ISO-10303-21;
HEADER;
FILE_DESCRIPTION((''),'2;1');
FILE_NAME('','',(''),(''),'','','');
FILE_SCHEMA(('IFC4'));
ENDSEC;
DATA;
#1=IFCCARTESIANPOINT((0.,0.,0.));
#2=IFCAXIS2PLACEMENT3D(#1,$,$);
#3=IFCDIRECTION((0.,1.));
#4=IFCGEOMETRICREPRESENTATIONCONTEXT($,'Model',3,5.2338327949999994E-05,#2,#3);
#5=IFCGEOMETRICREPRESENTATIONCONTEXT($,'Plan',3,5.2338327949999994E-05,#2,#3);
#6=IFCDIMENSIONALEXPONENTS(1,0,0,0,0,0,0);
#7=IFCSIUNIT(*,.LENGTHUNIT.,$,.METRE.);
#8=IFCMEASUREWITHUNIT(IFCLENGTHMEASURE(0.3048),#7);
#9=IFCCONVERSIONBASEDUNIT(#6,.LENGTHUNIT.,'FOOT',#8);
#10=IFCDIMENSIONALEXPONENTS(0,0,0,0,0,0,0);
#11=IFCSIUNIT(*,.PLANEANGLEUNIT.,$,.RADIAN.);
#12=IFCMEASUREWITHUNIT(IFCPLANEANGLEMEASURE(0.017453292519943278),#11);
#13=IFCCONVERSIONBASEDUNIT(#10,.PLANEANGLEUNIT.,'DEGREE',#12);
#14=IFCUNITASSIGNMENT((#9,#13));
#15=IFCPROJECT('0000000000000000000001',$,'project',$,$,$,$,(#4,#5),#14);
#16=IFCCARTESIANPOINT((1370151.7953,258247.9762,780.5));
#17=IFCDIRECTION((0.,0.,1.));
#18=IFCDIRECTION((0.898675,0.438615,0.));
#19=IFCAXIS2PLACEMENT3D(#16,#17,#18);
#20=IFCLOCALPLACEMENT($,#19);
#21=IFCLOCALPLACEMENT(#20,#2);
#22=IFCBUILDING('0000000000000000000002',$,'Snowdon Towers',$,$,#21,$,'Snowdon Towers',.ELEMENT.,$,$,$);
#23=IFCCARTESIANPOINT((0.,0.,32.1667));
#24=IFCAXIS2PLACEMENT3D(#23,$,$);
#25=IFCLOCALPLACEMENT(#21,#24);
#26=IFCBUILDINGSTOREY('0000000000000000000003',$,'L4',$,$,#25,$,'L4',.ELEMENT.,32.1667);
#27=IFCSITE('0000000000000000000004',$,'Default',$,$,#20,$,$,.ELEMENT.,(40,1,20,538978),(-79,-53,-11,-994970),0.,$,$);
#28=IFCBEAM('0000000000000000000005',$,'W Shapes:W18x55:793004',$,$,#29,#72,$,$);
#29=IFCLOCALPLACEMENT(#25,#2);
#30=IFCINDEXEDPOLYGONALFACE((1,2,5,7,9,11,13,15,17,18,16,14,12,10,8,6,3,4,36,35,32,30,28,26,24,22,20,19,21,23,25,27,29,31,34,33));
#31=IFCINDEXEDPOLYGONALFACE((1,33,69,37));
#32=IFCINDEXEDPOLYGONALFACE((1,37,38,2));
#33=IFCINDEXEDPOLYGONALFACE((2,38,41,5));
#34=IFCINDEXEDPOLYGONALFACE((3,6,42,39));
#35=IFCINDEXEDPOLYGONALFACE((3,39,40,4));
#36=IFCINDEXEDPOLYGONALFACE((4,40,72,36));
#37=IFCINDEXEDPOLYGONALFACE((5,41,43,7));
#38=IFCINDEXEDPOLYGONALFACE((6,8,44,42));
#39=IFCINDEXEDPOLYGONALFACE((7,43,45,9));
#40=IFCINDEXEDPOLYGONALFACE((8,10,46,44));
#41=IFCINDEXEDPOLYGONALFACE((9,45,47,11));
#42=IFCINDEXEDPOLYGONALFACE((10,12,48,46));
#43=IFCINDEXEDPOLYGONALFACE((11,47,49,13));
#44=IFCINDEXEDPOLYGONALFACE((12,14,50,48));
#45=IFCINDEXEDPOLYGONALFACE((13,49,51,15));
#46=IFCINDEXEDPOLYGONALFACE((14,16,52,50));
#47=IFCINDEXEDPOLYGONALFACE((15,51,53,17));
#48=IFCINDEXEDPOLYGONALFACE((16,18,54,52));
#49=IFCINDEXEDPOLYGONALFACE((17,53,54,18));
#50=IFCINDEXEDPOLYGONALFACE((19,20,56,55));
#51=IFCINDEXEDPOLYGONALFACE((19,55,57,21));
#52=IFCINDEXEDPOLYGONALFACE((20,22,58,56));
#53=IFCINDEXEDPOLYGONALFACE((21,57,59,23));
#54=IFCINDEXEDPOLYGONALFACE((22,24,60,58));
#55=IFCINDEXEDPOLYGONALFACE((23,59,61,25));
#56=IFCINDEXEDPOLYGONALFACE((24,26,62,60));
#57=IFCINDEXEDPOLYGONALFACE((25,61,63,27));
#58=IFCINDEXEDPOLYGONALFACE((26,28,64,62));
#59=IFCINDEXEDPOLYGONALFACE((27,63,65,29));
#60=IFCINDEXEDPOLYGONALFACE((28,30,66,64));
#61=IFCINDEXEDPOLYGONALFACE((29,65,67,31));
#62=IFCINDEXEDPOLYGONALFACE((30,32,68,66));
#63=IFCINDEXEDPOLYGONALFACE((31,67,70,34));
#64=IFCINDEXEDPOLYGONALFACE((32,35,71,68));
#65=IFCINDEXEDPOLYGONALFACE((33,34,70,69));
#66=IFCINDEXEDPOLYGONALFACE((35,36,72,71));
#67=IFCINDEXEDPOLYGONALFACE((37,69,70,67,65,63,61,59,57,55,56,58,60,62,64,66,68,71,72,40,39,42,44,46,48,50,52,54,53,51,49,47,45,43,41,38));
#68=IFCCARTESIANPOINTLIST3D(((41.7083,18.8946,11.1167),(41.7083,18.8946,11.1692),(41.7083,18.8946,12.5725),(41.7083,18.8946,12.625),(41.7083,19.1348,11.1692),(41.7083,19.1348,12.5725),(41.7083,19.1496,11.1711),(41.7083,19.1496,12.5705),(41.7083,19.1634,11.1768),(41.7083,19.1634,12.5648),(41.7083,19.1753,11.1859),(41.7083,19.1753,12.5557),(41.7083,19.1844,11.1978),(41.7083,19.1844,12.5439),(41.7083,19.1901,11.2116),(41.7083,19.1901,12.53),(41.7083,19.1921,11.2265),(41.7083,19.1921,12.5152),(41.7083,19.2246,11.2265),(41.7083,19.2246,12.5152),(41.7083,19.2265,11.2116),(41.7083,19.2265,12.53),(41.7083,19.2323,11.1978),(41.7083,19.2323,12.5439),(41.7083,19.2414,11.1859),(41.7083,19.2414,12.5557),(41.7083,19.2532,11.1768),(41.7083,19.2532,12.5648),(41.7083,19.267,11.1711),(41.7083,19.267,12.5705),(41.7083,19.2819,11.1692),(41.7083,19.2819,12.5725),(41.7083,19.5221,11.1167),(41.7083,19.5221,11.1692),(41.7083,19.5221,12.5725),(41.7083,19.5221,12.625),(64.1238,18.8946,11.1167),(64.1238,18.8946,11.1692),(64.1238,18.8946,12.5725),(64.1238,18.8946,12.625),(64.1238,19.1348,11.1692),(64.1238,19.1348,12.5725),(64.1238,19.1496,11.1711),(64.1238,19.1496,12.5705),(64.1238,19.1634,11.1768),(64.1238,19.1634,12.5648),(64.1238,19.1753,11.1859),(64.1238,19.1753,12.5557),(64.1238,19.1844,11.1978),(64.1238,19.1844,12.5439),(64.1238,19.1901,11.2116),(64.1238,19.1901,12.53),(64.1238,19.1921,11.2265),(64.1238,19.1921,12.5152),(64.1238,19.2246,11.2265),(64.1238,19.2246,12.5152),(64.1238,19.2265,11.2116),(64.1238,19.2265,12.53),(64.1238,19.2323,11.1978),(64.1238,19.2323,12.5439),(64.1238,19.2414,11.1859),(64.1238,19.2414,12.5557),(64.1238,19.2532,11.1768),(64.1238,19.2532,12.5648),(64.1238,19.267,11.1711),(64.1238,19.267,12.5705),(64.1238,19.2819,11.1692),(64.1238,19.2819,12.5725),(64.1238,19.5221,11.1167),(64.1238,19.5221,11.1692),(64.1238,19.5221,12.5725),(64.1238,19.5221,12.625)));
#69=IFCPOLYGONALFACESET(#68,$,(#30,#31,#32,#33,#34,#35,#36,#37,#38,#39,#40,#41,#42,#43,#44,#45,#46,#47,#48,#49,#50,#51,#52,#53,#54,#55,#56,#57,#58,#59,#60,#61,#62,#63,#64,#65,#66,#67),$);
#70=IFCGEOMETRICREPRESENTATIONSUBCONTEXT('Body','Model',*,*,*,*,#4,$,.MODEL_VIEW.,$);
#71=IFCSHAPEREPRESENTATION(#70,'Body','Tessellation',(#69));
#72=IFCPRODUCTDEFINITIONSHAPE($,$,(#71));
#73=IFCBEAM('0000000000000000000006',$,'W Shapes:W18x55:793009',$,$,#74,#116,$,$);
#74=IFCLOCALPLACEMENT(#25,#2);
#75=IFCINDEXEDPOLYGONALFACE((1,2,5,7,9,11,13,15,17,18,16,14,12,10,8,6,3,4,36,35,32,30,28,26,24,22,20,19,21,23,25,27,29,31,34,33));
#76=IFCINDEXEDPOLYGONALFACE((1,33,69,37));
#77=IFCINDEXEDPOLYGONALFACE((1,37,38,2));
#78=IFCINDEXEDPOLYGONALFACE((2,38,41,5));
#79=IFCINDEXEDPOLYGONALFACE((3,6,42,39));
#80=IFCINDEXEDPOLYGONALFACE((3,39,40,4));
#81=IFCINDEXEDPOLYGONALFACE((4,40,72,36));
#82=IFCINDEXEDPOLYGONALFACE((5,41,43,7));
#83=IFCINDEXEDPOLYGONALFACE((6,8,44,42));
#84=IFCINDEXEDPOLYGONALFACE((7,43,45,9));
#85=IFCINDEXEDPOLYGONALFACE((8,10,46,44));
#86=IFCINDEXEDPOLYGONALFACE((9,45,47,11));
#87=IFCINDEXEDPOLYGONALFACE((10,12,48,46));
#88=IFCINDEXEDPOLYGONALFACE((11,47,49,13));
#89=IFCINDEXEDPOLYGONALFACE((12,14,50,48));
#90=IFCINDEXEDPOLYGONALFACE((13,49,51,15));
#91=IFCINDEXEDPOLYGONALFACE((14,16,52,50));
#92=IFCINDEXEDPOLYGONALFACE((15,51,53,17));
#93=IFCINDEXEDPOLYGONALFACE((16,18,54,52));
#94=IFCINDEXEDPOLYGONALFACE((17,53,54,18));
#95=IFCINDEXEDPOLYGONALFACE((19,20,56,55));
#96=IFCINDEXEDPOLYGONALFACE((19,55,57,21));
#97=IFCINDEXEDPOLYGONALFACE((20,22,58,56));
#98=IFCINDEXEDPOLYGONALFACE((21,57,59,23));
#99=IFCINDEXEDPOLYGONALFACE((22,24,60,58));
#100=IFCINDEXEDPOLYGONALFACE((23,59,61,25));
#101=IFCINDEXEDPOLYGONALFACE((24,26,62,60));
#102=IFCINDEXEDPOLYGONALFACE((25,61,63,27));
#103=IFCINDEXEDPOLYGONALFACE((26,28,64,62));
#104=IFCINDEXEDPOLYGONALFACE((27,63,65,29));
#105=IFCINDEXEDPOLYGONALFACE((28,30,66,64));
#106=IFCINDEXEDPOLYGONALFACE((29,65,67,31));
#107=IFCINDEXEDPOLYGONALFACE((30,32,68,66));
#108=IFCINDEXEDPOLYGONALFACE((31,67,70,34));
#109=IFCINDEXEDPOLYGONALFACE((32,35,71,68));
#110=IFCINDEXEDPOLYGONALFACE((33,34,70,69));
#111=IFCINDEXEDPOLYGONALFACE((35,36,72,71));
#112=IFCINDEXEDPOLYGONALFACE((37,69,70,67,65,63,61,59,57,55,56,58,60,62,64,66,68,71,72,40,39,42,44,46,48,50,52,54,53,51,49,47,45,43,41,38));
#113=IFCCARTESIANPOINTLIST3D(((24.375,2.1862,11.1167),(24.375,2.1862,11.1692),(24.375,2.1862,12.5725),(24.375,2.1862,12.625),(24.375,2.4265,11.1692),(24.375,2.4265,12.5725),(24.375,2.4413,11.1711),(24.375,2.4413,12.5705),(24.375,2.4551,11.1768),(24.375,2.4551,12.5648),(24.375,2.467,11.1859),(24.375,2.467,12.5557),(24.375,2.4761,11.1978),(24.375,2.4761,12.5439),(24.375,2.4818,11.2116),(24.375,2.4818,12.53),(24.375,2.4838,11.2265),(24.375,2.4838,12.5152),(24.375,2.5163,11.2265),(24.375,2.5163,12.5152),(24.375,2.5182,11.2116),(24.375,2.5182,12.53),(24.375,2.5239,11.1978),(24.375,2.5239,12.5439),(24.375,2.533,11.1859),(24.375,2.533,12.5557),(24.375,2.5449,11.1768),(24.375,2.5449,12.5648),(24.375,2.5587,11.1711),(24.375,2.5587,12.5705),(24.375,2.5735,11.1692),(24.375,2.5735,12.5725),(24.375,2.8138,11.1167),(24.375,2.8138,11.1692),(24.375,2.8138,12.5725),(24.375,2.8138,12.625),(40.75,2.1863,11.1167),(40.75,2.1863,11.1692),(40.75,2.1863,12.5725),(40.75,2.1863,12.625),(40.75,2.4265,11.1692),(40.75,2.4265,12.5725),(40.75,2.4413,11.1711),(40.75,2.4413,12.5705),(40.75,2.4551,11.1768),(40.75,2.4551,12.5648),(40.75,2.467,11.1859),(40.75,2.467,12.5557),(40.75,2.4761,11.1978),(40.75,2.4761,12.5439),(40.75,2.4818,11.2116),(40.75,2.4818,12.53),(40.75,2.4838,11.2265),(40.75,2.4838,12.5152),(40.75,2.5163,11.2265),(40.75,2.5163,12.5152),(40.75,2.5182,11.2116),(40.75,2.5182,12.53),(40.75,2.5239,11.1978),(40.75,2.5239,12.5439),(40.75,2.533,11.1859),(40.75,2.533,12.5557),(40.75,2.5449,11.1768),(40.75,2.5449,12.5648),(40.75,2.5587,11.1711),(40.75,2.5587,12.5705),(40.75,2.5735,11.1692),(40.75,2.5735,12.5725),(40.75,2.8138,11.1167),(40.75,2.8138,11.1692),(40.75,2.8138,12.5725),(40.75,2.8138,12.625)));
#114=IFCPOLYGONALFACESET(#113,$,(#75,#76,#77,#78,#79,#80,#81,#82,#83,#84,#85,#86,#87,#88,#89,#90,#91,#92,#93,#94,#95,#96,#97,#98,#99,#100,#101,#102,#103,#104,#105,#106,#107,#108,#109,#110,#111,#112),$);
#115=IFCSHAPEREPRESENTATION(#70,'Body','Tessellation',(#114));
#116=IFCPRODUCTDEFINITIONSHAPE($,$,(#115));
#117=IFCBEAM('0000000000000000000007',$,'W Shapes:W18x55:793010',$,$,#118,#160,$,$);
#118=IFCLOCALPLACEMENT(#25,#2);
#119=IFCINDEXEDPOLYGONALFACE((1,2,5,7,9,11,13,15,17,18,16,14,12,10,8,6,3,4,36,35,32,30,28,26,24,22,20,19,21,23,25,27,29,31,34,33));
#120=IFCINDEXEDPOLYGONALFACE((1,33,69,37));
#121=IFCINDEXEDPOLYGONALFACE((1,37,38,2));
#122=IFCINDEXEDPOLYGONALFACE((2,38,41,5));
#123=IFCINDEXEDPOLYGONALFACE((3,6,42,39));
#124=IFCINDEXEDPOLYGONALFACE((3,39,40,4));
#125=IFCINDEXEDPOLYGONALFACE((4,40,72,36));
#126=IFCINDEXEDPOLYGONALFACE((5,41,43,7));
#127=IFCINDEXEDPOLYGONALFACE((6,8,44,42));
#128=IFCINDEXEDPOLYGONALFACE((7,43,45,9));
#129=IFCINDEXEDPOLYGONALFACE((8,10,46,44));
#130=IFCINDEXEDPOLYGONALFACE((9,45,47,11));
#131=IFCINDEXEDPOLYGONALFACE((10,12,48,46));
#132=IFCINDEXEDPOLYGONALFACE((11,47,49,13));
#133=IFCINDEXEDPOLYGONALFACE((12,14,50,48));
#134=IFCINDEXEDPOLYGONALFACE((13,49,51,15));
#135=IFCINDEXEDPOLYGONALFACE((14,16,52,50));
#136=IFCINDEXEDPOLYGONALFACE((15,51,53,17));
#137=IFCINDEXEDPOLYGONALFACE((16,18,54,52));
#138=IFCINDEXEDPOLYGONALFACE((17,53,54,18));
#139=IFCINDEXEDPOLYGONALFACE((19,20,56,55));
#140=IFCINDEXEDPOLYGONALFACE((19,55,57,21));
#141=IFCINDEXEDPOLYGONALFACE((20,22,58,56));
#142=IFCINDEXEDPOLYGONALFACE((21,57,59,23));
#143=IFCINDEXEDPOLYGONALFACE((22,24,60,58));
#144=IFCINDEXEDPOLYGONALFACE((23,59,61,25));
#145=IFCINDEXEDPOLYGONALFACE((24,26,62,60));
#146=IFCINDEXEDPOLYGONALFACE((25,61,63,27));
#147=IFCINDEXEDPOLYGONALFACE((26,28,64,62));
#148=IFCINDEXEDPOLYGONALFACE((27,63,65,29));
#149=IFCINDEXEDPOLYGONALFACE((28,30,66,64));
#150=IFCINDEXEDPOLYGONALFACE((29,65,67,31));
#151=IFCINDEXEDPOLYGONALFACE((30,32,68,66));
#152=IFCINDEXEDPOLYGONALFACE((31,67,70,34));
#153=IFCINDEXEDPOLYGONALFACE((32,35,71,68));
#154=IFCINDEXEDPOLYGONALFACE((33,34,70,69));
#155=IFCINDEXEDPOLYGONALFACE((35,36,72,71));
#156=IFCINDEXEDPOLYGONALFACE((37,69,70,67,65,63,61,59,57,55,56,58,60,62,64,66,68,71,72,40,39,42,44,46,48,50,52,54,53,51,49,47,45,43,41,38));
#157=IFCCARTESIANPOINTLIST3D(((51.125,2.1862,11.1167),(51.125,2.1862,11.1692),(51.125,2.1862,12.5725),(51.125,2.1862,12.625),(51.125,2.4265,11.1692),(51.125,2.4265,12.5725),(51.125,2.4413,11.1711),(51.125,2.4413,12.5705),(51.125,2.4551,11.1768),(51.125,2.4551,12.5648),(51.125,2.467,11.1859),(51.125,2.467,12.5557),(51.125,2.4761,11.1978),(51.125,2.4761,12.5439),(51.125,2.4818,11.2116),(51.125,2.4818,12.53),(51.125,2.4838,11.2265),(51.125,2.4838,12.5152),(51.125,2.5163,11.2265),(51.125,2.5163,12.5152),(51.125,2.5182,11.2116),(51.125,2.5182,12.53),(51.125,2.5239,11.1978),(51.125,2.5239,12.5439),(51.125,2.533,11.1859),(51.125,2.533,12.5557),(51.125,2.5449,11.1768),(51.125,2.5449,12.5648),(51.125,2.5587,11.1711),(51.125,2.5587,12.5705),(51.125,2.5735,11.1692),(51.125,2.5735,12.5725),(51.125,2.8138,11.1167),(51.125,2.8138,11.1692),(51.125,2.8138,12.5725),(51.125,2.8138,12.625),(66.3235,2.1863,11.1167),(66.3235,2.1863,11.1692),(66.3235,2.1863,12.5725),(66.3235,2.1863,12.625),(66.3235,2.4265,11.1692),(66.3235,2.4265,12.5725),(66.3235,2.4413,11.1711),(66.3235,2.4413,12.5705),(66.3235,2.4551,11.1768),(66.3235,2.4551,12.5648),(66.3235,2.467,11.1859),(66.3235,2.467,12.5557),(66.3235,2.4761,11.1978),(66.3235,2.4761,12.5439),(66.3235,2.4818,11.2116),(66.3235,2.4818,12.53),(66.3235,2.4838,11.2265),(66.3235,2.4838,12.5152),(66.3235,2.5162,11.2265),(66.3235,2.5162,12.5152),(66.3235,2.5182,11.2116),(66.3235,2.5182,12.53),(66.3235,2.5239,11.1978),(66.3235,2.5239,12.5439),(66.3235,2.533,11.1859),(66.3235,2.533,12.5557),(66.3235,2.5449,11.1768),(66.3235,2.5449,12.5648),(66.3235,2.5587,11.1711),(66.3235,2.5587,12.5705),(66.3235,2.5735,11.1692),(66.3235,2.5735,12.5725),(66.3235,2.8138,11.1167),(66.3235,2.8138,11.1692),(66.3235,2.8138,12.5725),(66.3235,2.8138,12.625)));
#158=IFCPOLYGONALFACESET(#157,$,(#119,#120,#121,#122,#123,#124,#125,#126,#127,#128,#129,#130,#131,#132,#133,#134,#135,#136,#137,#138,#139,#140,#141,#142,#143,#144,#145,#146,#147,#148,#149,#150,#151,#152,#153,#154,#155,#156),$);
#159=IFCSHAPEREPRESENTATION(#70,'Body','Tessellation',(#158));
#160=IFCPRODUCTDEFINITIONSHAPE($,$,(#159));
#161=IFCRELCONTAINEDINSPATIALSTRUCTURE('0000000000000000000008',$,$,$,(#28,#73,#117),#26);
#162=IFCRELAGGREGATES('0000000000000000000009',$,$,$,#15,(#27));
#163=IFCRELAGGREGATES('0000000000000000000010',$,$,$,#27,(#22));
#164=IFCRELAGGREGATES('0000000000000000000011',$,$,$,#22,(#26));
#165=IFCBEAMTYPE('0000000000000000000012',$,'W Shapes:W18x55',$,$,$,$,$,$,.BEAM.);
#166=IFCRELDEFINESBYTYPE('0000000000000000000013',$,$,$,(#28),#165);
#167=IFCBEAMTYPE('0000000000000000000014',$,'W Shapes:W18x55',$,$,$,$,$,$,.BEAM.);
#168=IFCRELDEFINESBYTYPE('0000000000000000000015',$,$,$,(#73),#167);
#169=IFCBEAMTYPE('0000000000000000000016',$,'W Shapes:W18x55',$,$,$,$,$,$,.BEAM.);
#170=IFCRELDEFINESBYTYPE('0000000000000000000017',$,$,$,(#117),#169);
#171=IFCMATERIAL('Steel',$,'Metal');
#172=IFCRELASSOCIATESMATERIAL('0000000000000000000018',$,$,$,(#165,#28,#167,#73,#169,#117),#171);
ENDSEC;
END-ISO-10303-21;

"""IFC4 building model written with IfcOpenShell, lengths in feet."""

from ifc_helpers import new_model, entity, si_unit, converted_unit, direction, frame, origin, place, context, subcontext, project, spatial, line, arc, indexed_curve, outline, extrude, source, transform, mapped, material, type_object, type_shapes, element, save


model = new_model("IFC4")

# Units and contexts
model_context = context("Model", 3, precision=5.2338327949999994e-05, world=origin(), true_north=direction((0.0, 1.0)))
plan_context = context("Plan", 3, precision=5.2338327949999994e-05, world=origin(), true_north=direction((0.0, 1.0)))
body_context = subcontext(model_context, "Body", "Model", "MODEL_VIEW")
ifc_project = project(units=[converted_unit("LENGTHUNIT", "FOOT", entity("IfcLengthMeasure", 0.3048), si_unit("LENGTHUNIT", "METRE"), dimensions=[1, 0, 0, 0, 0, 0, 0]), converted_unit("PLANEANGLEUNIT", "DEGREE", entity("IfcPlaneAngleMeasure", 0.017453292519943278), si_unit("PLANEANGLEUNIT", "RADIAN"), dimensions=[0, 0, 0, 0, 0, 0, 0])], contexts=[model_context, plan_context])

# Site, building, storey
site_placement = place(None, frame((1370151.7953, 258247.9762, 780.5), z_axis=(0.0, 0.0, 1.0), x_axis=(0.898675, 0.438615, 0.0)))
site = spatial("IfcSite", under=ifc_project, at=site_placement, Name="Default", CompositionType="ELEMENT", RefLatitude=(40, 1, 20, 538978), RefLongitude=(-79, -53, -11, -994970), RefElevation=0.0)
building_placement = place(site_placement, origin())
building = spatial("IfcBuilding", under=site, at=building_placement, Name="Snowdon Towers", LongName="Snowdon Towers", CompositionType="ELEMENT")
storey_placement = place(building_placement, frame((0.0, 0.0, 32.1667)))
storey = spatial("IfcBuildingStorey", under=building, at=storey_placement, Name="L4", LongName="L4", CompositionType="ELEMENT", Elevation=32.1667)

# Beams
ifc_material = material(Name="Steel", Category="Metal")
beam_type_1 = type_object("IfcBeamType", Name="W Shapes:W18x55", PredefinedType="BEAM", material=ifc_material)
shared_shape_1 = source(origin(), body_context, "Body", "SweptSolid", [
    extrude(outline(indexed_curve([(-0.7542, -0.3138), (-0.7017, -0.3138), (-0.7017, -0.0735), (-0.6849, -0.033), (-0.6444, -0.0162), (0.6444, -0.0162), (0.6849, -0.033), (0.7017, -0.0735), (0.7017, -0.3138), (0.7542, -0.3138), (0.7542, 0.3138), (0.7017, 0.3138), (0.7017, 0.0735), (0.6849, 0.033), (0.6444, 0.0163), (-0.6444, 0.0163), (-0.6849, 0.033), (-0.7017, 0.0735), (-0.7017, 0.3137), (-0.7542, 0.3137)], segments=[line(1, 2, 3), arc(3, 4, 5), line(5, 6), arc(6, 7, 8), line(8, 9, 10, 11, 12, 13), arc(13, 14, 15), line(15, 16), arc(16, 17, 18), line(18, 19, 20, 1)], self_intersect=False)), frame((-11.5915, 0.0, 0.0), z_axis=(1.0, 0.0, 0.0), x_axis=(0.0, 0.0, -1.0)), (0.0, 0.0, 1.0), 22.4154),
])
type_shapes(beam_type_1, [shared_shape_1])
beam_1_placement = place(storey_placement, frame((53.2998, 19.2083, 11.8708)))
element("IfcBeam", 1, at=beam_1_placement, inside=storey, type_object=beam_type_1, material=ifc_material, Name="W Shapes:W18x55:793004", context=body_context, shape_type="MappedRepresentation", body=[
    mapped(shared_shape_1, transform((0.0, 0.0, 0.0), scale=1.0)),
])
beam_type_2 = type_object("IfcBeamType", Name="W Shapes:W18x55", PredefinedType="BEAM", material=ifc_material)
shared_shape_2 = source(origin(), body_context, "Body", "SweptSolid", [
    extrude(outline(indexed_curve([(-0.7542, -0.3138), (-0.7017, -0.3138), (-0.7017, -0.0735), (-0.6849, -0.033), (-0.6444, -0.0162), (0.6444, -0.0162), (0.6849, -0.033), (0.7017, -0.0735), (0.7017, -0.3138), (0.7542, -0.3138), (0.7542, 0.3138), (0.7017, 0.3138), (0.7017, 0.0735), (0.6849, 0.033), (0.6444, 0.0163), (-0.6444, 0.0163), (-0.6849, 0.033), (-0.7017, 0.0735), (-0.7017, 0.3137), (-0.7542, 0.3137)], segments=[line(1, 2, 3), arc(3, 4, 5), line(5, 6), arc(6, 7, 8), line(8, 9, 10, 11, 12, 13), arc(13, 14, 15), line(15, 16), arc(16, 17, 18), line(18, 19, 20, 1)], self_intersect=False)), frame((-7.9583, 0.0, 0.0), z_axis=(1.0, 0.0, 0.0), x_axis=(0.0, 0.0, -1.0)), (0.0, 0.0, 1.0), 16.375),
])
type_shapes(beam_type_2, [shared_shape_2])
beam_2_placement = place(storey_placement, frame((32.3333, 2.5, 11.8708)))
element("IfcBeam", 2, at=beam_2_placement, inside=storey, type_object=beam_type_2, material=ifc_material, Name="W Shapes:W18x55:793009", context=body_context, shape_type="MappedRepresentation", body=[
    mapped(shared_shape_2, transform((0.0, 0.0, 0.0), scale=1.0)),
])
beam_type_3 = type_object("IfcBeamType", Name="W Shapes:W18x55", PredefinedType="BEAM", material=ifc_material)
shared_shape_3 = source(origin(), body_context, "Body", "SweptSolid", [
    extrude(outline(indexed_curve([(-0.7542, -0.3138), (-0.7017, -0.3138), (-0.7017, -0.0735), (-0.6849, -0.033), (-0.6444, -0.0162), (0.6444, -0.0162), (0.6849, -0.033), (0.7017, -0.0735), (0.7017, -0.3138), (0.7542, -0.3138), (0.7542, 0.3138), (0.7017, 0.3138), (0.7017, 0.0735), (0.6849, 0.033), (0.6444, 0.0163), (-0.6444, 0.0163), (-0.6849, 0.033), (-0.7017, 0.0735), (-0.7017, 0.3137), (-0.7542, 0.3137)], segments=[line(1, 2, 3), arc(3, 4, 5), line(5, 6), arc(6, 7, 8), line(8, 9, 10, 11, 12, 13), arc(13, 14, 15), line(15, 16), arc(16, 17, 18), line(18, 19, 20, 1)], self_intersect=False)), frame((-8.2122, 0.0, 0.0), z_axis=(1.0, 0.0, 0.0), x_axis=(0.0, 0.0, -1.0)), (0.0, 0.0, 1.0), 15.1985),
])
type_shapes(beam_type_3, [shared_shape_3])
beam_3_placement = place(storey_placement, frame((59.3372, 2.5, 11.8708)))
element("IfcBeam", 3, at=beam_3_placement, inside=storey, type_object=beam_type_3, material=ifc_material, Name="W Shapes:W18x55:793010", context=body_context, shape_type="MappedRepresentation", body=[
    mapped(shared_shape_3, transform((0.0, 0.0, 0.0), scale=1.0)),
])

save(model, "model.ifc")
